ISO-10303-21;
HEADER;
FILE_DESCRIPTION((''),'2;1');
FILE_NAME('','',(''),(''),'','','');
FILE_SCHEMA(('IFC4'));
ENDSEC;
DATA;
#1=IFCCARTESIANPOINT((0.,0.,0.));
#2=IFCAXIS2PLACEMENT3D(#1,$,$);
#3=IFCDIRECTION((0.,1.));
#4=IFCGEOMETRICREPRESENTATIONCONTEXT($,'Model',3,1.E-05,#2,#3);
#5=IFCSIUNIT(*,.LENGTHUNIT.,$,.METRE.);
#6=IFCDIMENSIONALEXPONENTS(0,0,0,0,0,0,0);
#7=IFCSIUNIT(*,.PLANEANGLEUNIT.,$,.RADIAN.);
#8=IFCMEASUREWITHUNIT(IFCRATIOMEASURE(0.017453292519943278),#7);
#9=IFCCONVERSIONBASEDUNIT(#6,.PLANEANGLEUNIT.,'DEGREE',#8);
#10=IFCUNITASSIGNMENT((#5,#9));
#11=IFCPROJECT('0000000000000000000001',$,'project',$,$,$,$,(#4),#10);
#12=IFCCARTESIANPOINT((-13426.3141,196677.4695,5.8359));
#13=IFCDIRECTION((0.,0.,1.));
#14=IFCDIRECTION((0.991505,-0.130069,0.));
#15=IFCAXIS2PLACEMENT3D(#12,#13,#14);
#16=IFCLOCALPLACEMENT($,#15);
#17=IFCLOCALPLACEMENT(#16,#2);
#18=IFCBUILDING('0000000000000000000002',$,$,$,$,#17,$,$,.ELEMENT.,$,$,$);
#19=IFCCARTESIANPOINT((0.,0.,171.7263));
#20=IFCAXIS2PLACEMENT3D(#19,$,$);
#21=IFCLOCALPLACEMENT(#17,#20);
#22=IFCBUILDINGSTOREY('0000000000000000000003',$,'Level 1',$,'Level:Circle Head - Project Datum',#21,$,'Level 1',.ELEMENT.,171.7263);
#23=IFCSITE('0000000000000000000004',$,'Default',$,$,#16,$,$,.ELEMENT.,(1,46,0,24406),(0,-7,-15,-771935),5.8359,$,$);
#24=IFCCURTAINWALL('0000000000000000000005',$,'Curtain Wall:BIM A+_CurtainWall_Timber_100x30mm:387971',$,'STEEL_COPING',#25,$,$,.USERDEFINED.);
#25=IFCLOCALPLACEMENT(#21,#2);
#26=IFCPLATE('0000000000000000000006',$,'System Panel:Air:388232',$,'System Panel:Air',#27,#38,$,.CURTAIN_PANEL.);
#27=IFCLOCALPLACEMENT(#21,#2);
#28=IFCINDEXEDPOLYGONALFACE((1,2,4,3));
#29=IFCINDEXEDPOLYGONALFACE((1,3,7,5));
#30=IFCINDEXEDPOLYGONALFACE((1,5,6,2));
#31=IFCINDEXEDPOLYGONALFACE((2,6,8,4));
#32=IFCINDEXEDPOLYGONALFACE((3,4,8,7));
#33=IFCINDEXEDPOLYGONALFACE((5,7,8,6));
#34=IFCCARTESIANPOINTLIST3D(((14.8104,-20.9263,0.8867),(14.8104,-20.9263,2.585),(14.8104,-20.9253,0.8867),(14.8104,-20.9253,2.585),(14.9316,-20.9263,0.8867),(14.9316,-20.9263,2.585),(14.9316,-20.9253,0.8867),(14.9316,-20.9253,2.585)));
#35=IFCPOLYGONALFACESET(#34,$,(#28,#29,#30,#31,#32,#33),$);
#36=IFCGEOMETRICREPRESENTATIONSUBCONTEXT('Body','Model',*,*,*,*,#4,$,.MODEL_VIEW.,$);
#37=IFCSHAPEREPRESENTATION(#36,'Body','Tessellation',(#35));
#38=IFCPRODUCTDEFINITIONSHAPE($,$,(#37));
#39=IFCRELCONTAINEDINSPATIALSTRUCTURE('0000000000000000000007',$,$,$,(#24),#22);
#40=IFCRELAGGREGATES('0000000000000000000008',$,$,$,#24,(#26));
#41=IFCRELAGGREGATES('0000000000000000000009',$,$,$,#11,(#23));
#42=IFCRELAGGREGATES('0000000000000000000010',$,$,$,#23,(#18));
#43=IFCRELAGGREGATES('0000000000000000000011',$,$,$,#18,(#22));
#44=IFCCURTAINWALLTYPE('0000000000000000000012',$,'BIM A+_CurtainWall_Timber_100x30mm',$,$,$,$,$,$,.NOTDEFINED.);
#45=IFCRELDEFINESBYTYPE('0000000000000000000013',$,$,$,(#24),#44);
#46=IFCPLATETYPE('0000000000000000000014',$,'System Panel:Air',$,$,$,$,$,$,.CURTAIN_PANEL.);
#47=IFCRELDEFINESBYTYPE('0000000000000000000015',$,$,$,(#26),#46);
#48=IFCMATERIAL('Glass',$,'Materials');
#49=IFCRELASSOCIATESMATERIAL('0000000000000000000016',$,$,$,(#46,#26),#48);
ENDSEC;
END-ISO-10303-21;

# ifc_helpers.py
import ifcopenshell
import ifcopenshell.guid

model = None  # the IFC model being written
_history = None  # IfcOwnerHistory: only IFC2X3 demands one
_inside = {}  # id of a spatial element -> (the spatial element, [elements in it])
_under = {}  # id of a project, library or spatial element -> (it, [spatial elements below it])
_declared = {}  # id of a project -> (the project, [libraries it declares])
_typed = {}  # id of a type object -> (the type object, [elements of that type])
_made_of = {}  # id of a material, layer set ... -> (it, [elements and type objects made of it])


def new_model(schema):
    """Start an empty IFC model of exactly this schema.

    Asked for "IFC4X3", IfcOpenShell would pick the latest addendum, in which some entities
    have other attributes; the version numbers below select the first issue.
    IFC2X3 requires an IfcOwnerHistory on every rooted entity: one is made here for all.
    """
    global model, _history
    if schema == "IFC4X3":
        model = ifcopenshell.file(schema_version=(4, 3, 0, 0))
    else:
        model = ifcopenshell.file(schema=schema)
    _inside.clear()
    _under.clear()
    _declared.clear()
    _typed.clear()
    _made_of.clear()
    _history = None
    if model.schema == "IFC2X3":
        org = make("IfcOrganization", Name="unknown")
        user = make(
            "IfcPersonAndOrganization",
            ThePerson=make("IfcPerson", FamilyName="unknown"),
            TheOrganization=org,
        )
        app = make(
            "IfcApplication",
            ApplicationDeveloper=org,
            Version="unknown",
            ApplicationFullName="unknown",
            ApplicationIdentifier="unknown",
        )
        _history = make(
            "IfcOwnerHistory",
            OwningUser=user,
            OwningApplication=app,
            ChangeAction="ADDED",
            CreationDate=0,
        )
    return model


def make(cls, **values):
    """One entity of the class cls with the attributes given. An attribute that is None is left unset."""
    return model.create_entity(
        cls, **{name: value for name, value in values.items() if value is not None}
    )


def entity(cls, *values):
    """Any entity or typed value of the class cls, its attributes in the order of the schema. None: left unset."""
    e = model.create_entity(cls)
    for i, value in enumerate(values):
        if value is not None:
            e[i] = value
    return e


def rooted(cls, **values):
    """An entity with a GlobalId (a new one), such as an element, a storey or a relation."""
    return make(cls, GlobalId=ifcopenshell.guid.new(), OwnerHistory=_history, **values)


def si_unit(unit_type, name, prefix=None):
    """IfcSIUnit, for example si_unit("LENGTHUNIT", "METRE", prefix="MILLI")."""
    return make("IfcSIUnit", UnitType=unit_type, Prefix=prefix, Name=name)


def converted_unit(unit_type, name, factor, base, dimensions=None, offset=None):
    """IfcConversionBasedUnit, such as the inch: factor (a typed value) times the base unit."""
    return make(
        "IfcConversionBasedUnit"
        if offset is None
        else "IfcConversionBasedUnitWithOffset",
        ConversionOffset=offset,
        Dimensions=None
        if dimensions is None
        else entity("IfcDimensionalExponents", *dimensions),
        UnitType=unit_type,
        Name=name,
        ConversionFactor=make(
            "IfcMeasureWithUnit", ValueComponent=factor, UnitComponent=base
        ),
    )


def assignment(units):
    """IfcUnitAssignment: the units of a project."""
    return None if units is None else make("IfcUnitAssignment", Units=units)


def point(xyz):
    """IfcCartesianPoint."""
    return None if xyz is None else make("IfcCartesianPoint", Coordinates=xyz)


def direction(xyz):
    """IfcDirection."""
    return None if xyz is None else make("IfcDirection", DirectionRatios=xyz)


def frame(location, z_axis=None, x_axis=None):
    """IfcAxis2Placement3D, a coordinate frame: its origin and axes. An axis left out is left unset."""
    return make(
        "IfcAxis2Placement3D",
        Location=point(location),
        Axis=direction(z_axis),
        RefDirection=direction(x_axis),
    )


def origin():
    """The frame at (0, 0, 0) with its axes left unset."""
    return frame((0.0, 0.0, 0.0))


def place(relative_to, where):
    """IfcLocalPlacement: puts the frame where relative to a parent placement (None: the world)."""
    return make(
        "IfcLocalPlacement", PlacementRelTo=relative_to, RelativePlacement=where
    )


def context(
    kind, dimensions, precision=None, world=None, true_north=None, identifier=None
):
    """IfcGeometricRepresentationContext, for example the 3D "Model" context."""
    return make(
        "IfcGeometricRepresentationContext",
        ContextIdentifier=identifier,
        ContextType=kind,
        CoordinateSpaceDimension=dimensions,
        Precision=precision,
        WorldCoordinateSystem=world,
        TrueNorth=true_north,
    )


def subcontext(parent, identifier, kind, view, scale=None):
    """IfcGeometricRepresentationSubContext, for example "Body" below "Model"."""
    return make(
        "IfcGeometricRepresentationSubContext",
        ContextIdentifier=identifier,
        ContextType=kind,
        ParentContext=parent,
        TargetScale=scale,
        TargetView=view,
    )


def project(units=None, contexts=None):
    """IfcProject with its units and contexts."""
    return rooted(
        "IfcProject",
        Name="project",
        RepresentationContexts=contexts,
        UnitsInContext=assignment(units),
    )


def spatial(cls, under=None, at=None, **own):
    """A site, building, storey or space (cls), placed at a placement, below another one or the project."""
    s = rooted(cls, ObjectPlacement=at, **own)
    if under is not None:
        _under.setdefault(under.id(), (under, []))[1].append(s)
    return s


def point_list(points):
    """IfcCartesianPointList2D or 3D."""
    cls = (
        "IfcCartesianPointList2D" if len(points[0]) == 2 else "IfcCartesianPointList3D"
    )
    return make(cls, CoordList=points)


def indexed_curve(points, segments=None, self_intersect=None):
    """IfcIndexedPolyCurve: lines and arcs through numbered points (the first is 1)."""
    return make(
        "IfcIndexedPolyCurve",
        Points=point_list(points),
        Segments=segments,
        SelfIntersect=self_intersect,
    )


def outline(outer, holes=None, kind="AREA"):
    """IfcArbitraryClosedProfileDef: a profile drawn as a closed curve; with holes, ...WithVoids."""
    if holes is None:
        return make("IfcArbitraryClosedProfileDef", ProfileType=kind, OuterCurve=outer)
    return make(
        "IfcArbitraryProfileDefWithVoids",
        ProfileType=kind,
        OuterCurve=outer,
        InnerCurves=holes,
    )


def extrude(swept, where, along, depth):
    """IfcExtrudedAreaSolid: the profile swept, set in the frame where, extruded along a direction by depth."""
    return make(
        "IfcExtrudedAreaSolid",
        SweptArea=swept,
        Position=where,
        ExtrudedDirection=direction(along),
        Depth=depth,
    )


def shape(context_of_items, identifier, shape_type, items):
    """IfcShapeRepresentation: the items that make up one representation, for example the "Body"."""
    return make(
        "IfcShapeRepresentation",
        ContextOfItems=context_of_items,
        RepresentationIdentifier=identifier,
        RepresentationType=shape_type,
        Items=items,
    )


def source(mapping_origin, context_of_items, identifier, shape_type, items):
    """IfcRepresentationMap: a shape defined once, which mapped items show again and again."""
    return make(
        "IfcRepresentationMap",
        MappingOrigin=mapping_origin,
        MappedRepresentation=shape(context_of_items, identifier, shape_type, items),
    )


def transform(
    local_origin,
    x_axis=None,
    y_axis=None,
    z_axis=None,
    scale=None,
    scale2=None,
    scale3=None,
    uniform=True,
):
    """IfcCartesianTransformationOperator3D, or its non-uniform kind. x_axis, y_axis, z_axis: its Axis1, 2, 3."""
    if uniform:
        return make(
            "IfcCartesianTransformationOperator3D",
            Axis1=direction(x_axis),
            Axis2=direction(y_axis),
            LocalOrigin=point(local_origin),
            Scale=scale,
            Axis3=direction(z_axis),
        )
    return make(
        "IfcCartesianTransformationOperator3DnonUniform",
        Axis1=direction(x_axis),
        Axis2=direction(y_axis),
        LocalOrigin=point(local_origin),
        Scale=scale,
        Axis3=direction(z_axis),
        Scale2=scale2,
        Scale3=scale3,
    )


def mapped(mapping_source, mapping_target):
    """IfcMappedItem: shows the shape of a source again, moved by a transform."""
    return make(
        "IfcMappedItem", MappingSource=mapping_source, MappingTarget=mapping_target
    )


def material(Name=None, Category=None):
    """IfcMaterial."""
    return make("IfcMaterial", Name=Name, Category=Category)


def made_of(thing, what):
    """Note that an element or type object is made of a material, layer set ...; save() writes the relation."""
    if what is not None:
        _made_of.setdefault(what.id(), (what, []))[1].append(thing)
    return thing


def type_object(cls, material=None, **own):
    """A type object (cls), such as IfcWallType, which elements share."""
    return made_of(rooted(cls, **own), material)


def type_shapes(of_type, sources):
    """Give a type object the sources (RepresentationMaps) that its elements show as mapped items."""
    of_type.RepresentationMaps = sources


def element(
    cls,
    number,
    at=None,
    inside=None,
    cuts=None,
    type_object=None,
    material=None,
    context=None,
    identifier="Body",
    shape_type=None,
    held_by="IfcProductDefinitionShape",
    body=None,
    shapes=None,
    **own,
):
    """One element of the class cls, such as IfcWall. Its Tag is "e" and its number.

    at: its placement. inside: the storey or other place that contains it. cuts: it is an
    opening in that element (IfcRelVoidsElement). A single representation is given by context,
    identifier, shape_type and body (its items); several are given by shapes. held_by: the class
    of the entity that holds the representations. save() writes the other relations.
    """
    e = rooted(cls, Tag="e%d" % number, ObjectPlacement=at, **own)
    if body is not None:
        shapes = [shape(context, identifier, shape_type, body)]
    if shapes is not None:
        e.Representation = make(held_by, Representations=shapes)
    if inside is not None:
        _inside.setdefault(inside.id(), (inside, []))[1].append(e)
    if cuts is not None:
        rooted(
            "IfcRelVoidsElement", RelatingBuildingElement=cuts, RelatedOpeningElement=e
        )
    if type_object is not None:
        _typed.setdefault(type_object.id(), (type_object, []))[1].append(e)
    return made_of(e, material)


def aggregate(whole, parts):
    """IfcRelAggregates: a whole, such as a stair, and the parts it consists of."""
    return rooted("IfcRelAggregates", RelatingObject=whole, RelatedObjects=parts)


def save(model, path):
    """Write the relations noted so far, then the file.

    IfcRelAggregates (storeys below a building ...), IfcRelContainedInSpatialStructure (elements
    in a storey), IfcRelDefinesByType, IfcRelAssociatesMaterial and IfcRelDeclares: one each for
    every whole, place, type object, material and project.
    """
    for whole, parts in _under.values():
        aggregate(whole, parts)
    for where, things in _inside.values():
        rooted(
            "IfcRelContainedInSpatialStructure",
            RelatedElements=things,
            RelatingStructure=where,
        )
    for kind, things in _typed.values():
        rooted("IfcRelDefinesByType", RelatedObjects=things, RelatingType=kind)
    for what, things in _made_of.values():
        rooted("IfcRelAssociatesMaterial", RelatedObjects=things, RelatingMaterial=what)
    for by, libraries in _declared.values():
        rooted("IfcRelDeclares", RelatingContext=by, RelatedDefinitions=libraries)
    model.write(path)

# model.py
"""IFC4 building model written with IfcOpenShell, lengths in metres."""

from ifc_helpers import new_model, entity, si_unit, converted_unit, direction, frame, origin, place, context, subcontext, project, spatial, indexed_curve, outline, extrude, source, transform, mapped, material, type_object, type_shapes, element, aggregate, save


model = new_model("IFC4")

# Units and contexts
model_context = context("Model", 3, precision=1e-05, world=origin(), true_north=direction((0.0, 1.0)))
body_context = subcontext(model_context, "Body", "Model", "MODEL_VIEW")
ifc_project = project(units=[si_unit("LENGTHUNIT", "METRE"), converted_unit("PLANEANGLEUNIT", "DEGREE", entity("IfcRatioMeasure", 0.017453292519943278), si_unit("PLANEANGLEUNIT", "RADIAN"), dimensions=[0, 0, 0, 0, 0, 0, 0])], contexts=[model_context])

# Site, building, storey
site_placement = place(None, frame((-13426.3141, 196677.4695, 5.8359), z_axis=(0.0, 0.0, 1.0), x_axis=(0.991505, -0.130069, 0.0)))
site = spatial("IfcSite", under=ifc_project, at=site_placement, Name="Default", CompositionType="ELEMENT", RefLatitude=(1, 46, 0, 24406), RefLongitude=(0, -7, -15, -771935), RefElevation=5.8359)
building_placement = place(site_placement, origin())
building = spatial("IfcBuilding", under=site, at=building_placement, CompositionType="ELEMENT")
storey_placement = place(building_placement, frame((0.0, 0.0, 171.7263)))
storey = spatial("IfcBuildingStorey", under=building, at=storey_placement, Name="Level 1", ObjectType="Level:Circle Head - Project Datum", LongName="Level 1", CompositionType="ELEMENT", Elevation=171.7263)

# Curtain wall
curtain_wall_type_1 = type_object("IfcCurtainWallType", Name="BIM A+_CurtainWall_Timber_100x30mm", PredefinedType="NOTDEFINED")
curtain_wall_1_placement = place(storey_placement, frame((0.0, 0.0, -171.7263)))
curtain_wall_1 = element("IfcCurtainWall", 1, at=curtain_wall_1_placement, inside=storey, type_object=curtain_wall_type_1, Name="Curtain Wall:BIM A+_CurtainWall_Timber_100x30mm:387971", ObjectType="STEEL_COPING", PredefinedType="USERDEFINED")

# Plate
ifc_material_1 = material(Name="Glass", Category="Materials")
plate_type_1 = type_object("IfcPlateType", Name="System Panel:Air", PredefinedType="CURTAIN_PANEL", material=ifc_material_1)
shared_shape_1 = source(origin(), body_context, "Body", "SweptSolid", [
    extrude(outline(indexed_curve([(-0.0005, -0.0606), (0.0005, -0.0606), (0.0005, 0.0606), (-0.0005, 0.0606), (-0.0005, -0.0606)], self_intersect=False)), frame((0.0, 0.0, 0.0), z_axis=(0.0, 0.0, 1.0), x_axis=(0.0, 1.0, 0.0)), (0.0, 0.0, 1.0), 1.6983),
])
type_shapes(plate_type_1, [shared_shape_1])
plate_1_placement = place(curtain_wall_1_placement, frame((14.871, -20.9258, 172.613)))
plate_1 = element("IfcPlate", 2, at=plate_1_placement, type_object=plate_type_1, material=ifc_material_1, Name="System Panel:Air:388232", ObjectType="System Panel:Air", PredefinedType="CURTAIN_PANEL", context=body_context, shape_type="MappedRepresentation", body=[
    mapped(shared_shape_1, transform((0.0, 0.0, 0.0), scale=1.0)),
])
aggregate(curtain_wall_1, [plate_1])

save(model, "model.ifc")
